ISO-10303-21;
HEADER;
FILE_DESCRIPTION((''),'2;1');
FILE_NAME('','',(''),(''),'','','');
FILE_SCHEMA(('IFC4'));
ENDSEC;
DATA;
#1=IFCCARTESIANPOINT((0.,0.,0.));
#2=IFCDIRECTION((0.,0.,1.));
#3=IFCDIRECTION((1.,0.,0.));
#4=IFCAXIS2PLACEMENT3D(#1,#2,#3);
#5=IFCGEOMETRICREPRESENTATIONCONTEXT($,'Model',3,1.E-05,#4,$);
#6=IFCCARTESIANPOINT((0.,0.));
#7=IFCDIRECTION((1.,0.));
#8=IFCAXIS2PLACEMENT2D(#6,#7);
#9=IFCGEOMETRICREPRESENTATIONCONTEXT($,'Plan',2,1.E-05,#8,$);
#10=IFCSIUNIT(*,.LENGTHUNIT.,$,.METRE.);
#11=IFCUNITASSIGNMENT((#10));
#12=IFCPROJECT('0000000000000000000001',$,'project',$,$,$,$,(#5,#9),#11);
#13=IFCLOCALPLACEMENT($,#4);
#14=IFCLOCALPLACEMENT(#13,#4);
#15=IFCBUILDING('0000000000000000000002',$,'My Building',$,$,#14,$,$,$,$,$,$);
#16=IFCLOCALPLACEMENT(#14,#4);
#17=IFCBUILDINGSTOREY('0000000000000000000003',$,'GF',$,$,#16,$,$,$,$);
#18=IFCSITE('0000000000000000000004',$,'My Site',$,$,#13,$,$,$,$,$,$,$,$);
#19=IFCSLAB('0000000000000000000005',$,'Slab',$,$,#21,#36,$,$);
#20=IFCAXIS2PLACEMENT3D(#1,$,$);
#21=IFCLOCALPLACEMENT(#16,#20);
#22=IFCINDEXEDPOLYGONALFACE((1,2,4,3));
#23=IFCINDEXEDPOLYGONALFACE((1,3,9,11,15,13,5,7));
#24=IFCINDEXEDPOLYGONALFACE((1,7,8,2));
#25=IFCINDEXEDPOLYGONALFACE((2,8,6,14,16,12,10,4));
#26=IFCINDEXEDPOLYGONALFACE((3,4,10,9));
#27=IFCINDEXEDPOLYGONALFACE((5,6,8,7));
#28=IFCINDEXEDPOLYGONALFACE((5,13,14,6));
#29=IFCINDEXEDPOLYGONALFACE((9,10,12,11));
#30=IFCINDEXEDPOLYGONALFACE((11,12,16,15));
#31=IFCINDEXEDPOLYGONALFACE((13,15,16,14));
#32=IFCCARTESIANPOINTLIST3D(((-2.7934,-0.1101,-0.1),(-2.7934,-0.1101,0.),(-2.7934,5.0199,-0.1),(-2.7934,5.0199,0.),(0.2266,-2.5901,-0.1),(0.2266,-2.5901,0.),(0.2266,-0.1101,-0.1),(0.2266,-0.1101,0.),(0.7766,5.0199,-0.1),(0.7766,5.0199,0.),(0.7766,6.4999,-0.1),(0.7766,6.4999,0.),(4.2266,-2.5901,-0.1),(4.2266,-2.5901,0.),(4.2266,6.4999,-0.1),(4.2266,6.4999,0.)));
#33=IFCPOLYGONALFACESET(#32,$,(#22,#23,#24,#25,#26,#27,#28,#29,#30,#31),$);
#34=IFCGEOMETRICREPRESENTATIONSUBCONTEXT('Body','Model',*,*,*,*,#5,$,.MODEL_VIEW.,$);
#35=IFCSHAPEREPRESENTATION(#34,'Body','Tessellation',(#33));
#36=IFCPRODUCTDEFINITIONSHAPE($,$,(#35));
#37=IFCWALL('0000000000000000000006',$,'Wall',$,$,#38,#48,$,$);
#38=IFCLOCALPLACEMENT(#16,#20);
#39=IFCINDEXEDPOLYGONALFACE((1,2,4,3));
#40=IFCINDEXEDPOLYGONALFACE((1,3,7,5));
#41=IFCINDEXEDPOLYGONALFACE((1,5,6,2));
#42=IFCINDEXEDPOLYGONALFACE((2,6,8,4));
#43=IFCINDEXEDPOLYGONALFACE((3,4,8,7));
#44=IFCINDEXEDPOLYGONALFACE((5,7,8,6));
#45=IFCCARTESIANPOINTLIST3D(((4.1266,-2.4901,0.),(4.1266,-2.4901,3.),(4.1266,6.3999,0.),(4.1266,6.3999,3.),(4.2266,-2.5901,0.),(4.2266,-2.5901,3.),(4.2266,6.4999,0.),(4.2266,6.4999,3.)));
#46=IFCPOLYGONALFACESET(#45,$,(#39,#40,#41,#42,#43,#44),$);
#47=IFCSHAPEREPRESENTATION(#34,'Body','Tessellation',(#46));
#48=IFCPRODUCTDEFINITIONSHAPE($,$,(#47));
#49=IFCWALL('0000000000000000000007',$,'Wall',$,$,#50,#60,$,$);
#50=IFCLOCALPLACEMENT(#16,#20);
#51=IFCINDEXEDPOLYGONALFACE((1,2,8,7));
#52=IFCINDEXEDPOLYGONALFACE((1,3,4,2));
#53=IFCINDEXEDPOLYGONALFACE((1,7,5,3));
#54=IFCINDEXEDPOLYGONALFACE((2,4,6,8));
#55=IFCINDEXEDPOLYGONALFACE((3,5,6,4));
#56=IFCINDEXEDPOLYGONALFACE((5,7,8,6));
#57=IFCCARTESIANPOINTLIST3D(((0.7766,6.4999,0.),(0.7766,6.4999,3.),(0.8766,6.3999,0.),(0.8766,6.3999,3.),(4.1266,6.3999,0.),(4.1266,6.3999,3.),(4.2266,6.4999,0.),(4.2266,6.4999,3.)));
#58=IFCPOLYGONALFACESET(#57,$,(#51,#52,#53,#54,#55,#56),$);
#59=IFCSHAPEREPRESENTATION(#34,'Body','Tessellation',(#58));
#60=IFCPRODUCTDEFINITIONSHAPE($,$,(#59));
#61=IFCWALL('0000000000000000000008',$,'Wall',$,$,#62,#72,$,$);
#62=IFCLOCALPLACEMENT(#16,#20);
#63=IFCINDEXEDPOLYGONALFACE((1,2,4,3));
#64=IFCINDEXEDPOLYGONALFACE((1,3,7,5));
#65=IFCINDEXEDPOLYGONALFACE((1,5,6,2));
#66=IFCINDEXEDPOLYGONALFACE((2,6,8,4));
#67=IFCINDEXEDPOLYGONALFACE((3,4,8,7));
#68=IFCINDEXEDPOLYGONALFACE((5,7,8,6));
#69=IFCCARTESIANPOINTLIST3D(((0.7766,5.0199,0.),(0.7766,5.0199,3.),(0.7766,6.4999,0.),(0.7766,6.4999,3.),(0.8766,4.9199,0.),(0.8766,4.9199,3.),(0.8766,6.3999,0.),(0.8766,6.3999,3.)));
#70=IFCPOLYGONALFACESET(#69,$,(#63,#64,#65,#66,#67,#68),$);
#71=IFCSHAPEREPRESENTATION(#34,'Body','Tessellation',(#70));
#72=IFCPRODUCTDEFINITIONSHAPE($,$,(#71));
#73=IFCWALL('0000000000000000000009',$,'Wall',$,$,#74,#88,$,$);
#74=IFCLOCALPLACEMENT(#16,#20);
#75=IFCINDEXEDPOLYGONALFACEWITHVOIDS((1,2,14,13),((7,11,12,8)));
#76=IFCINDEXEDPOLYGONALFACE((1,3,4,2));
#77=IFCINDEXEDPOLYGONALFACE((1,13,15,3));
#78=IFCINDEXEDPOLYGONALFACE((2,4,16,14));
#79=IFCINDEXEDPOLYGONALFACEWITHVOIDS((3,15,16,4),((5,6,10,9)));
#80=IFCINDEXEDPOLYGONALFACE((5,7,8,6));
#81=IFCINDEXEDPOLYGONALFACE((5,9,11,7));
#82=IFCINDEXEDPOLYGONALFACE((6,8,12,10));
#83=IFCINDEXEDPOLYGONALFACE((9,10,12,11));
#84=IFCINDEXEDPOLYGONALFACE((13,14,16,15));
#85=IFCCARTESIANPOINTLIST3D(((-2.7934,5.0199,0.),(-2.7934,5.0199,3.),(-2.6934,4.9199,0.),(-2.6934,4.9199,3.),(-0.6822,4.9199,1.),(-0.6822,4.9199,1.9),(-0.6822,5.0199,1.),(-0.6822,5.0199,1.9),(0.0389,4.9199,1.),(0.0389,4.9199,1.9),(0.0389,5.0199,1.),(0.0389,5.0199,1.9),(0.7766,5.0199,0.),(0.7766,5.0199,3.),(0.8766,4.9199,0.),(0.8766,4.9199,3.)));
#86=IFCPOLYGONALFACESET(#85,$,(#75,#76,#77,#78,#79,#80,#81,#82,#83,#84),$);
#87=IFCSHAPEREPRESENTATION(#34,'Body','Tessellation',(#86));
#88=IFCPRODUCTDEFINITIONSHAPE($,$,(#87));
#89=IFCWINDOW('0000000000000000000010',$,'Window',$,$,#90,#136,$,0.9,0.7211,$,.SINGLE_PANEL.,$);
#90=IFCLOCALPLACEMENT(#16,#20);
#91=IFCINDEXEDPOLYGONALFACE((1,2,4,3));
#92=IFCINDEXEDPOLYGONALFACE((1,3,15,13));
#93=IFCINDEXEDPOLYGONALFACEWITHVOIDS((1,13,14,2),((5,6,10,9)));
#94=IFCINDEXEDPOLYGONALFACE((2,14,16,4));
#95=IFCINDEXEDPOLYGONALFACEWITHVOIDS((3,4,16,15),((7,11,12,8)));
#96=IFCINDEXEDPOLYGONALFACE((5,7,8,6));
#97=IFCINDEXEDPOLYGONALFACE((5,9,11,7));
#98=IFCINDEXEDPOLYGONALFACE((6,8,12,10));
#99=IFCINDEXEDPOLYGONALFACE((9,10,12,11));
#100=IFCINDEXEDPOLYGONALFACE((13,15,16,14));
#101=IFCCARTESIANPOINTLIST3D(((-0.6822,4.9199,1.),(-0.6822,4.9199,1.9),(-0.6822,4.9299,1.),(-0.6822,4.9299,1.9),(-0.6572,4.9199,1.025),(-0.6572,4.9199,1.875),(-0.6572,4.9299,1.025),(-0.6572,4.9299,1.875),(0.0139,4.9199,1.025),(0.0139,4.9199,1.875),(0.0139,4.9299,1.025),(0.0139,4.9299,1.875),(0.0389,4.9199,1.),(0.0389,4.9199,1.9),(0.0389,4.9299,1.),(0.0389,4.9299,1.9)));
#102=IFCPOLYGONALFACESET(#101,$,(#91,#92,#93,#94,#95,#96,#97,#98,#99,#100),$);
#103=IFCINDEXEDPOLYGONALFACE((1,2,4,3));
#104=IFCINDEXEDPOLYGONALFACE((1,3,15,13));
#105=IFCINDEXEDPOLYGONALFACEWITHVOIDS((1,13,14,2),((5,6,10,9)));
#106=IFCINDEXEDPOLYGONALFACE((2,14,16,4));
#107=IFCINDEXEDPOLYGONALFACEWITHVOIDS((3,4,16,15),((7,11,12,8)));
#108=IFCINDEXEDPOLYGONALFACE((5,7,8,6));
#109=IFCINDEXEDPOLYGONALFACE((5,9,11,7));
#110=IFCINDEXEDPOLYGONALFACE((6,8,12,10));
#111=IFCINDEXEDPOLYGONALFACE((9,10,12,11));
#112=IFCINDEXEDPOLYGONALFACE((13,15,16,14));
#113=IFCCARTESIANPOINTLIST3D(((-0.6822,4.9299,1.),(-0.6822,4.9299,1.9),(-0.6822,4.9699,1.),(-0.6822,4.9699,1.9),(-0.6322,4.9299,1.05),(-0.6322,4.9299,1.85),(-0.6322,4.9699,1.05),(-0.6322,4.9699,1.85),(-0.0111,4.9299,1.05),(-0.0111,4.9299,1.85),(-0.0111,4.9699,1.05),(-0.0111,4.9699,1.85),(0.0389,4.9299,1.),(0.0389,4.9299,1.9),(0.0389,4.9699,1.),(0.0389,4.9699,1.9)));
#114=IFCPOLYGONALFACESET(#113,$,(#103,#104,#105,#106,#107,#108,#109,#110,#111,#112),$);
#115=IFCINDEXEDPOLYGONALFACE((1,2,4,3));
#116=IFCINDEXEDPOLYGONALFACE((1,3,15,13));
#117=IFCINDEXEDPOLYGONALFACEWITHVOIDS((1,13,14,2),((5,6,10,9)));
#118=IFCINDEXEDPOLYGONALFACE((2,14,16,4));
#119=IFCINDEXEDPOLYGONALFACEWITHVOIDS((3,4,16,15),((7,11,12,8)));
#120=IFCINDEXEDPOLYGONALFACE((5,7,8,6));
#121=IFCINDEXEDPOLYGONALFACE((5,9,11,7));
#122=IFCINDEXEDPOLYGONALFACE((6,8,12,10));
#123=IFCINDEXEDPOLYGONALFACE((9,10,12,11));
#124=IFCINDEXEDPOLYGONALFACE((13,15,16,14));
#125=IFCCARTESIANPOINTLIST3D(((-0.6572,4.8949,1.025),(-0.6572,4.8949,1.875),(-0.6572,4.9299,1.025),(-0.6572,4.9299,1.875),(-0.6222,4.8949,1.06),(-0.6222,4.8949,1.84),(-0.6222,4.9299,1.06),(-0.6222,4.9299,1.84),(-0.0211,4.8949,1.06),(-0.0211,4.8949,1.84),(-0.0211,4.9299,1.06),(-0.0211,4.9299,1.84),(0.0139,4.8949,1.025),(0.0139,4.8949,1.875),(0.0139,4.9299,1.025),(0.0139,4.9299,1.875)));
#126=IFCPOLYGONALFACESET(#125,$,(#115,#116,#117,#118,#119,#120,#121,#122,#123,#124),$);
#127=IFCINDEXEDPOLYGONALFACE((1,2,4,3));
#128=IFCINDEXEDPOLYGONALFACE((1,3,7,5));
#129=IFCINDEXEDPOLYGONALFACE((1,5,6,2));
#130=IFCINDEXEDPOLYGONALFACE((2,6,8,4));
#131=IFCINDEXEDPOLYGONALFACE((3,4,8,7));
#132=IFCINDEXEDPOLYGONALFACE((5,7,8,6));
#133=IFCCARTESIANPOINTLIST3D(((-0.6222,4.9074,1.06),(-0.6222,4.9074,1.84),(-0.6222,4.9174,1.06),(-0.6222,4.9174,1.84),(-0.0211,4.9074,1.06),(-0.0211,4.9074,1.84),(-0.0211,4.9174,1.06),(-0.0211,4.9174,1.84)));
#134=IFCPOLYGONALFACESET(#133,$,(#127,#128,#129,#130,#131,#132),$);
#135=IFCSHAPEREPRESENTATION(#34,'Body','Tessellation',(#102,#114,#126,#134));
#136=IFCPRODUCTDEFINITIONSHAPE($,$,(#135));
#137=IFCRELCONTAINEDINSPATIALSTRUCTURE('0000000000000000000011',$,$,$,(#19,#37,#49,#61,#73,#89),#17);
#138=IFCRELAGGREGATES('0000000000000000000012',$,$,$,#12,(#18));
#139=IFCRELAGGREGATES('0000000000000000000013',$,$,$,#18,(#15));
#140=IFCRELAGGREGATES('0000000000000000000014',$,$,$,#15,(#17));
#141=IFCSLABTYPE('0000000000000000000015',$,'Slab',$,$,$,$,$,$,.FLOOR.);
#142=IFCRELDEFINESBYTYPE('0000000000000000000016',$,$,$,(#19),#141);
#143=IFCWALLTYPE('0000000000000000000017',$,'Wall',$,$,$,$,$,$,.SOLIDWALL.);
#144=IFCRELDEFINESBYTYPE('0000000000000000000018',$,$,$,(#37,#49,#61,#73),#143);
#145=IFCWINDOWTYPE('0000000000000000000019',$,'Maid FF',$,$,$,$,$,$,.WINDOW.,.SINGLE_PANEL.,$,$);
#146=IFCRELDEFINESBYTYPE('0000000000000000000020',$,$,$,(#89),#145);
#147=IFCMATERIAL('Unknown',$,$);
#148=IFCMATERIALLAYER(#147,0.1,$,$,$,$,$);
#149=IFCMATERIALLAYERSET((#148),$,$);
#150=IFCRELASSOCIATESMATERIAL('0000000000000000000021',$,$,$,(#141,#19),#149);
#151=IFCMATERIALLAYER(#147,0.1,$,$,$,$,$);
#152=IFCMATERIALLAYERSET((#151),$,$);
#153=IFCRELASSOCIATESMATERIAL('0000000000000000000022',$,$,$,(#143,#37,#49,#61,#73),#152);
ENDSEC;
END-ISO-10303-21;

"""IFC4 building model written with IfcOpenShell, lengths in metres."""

from ifc_helpers import new_model, entity, si_unit, frame, origin_with_axes, origin_2d_with_axis, place, context, subcontext, project, spatial, line, indexed_curve, outline, extrude, shape, source, transform, mapped, material, layer, layer_set, layer_usage, type_object, type_shapes, element, fill, save


model = new_model("IFC4")

# Units and contexts
model_context = context("Model", 3, precision=1e-05, world=origin_with_axes())
plan_context = context("Plan", 2, precision=1e-05, world=origin_2d_with_axis())
body_context_1 = subcontext(model_context, "Body", "Model", "MODEL_VIEW")
body_context_2 = subcontext(plan_context, "Body", "Plan", "PLAN_VIEW")
ifc_project = project(units=[si_unit("LENGTHUNIT", "METRE")], contexts=[model_context, plan_context])

# Site, building, storey
site_placement = place(None, origin_with_axes())
site = spatial("IfcSite", under=ifc_project, at=site_placement, Name="My Site")
building_placement = place(site_placement, origin_with_axes())
building = spatial("IfcBuilding", under=site, at=building_placement, Name="My Building")
storey_placement = place(building_placement, origin_with_axes())
storey = spatial("IfcBuildingStorey", under=building, at=storey_placement, Name="GF")

# Slab
ifc_material_1 = material(Name="Unknown")
ifc_layer_1 = layer(ifc_material_1, 0.1)
ifc_layer_set_1 = layer_set([ifc_layer_1])
ifc_layer_usage_1 = layer_usage(ifc_layer_set_1, "AXIS3", "POSITIVE", -0.1)
slab_type_1 = type_object("IfcSlabType", Name="Slab", PredefinedType="FLOOR", material=ifc_layer_set_1)
slab_1_placement = place(storey_placement, frame((4.2266, -2.5901, 0.0), z_axis=(0.0, 0.0, 1.0), x_axis=(1.0, 0.0, 0.0)))
element("IfcSlab", 1, at=slab_1_placement, inside=storey, type_object=slab_type_1, material=ifc_layer_usage_1, Name="Slab", context=body_context_1, shape_type="SweptSolid", body=[
    extrude(outline(indexed_curve([(0.0, 0.0), (0.0, 9.09), (-3.45, 9.09), (-3.45, 7.61), (-7.02, 7.61), (-7.02, 2.48), (-4.0, 2.48), (-4.0, 0.0), (0.0, 0.0)])), frame((0.0, 0.0, -0.1), z_axis=(0.0, 0.0, 1.0), x_axis=(1.0, 0.0, 0.0)), (0.0, 0.0, 1.0), 0.1),
])

# Shared definitions
ifc_layer_2 = layer(ifc_material_1, 0.1)
ifc_layer_set_2 = layer_set([ifc_layer_2])
wall_type = type_object("IfcWallType", Name="Wall", PredefinedType="SOLIDWALL", material=ifc_layer_set_2)

# Walls
ifc_layer_usage_2 = layer_usage(ifc_layer_set_2, "AXIS2", "POSITIVE", 0.0)
wall_1_placement = place(storey_placement, frame((4.2266, -2.5901, 0.0), z_axis=(0.0, 0.0, 1.0), x_axis=(0.0, 1.0, 0.0)))
element("IfcWall", 2, at=wall_1_placement, inside=storey, type_object=wall_type, material=ifc_layer_usage_2, Name="Wall", context=body_context_1, shape_type="SweptSolid", body=[
    extrude(outline(indexed_curve([(0.0, 0.0), (0.1, 0.1), (8.99, 0.1), (9.09, 0.0)], segments=[line(1, 2, 3, 4, 1)])), origin_with_axes(), (0.0, 0.0, 1.0), 3.0),
])
ifc_layer_usage_3 = layer_usage(ifc_layer_set_2, "AXIS2", "POSITIVE", 0.0)
wall_2_placement = place(storey_placement, frame((4.2266, 6.4999, 0.0), z_axis=(0.0, 0.0, 1.0), x_axis=(-1.0, 0.0, 0.0)))
element("IfcWall", 3, at=wall_2_placement, inside=storey, type_object=wall_type, material=ifc_layer_usage_3, Name="Wall", context=body_context_1, shape_type="SweptSolid", body=[
    extrude(outline(indexed_curve([(0.0, 0.0), (0.1, 0.1), (3.35, 0.1), (3.45, 0.0)], segments=[line(1, 2, 3, 4, 1)])), origin_with_axes(), (0.0, 0.0, 1.0), 3.0),
])
ifc_layer_usage_4 = layer_usage(ifc_layer_set_2, "AXIS2", "POSITIVE", 0.0)
wall_3_placement = place(storey_placement, frame((0.7766, 6.4999, 0.0), z_axis=(0.0, 0.0, 1.0), x_axis=(0.0, -1.0, 0.0)))
element("IfcWall", 4, at=wall_3_placement, inside=storey, type_object=wall_type, material=ifc_layer_usage_4, Name="Wall", context=body_context_1, shape_type="SweptSolid", body=[
    extrude(outline(indexed_curve([(0.0, 0.0), (0.1, 0.1), (1.58, 0.1), (1.48, 0.0)], segments=[line(1, 2, 3, 4, 1)])), origin_with_axes(), (0.0, 0.0, 1.0), 3.0),
])

# Wall, opening, window
ifc_layer_usage_5 = layer_usage(ifc_layer_set_2, "AXIS2", "POSITIVE", 0.0)
wall_4_placement = place(storey_placement, frame((0.7766, 5.0199, 0.0), z_axis=(0.0, 0.0, 1.0), x_axis=(-1.0, 0.0, 0.0)))
wall_4 = element("IfcWall", 5, at=wall_4_placement, inside=storey, type_object=wall_type, material=ifc_layer_usage_5, Name="Wall", context=body_context_1, shape_type="SweptSolid", body=[
    extrude(outline(indexed_curve([(0.0, 0.0), (-0.1, 0.1), (3.47, 0.1), (3.57, 0.0)], segments=[line(1, 2, 3, 4, 1)])), origin_with_axes(), (0.0, 0.0, 1.0), 3.0),
])
shared_shape_1 = source(origin_with_axes(), body_context_1, "Body", "SweptSolid", [
    extrude(outline(indexed_curve([(0.0, 0.0), (0.7211, 0.0), (0.7211, 0.9), (0.0, 0.9)], segments=[line(1, 2, 3, 4, 1)])), frame((0.0, -0.6, 0.0), z_axis=(0.0, -1.0, 0.0), x_axis=(1.0, 0.0, 0.0)), (0.0, 0.0, -1.0), 1.2),
])
opening_1_placement = place(wall_4_placement, frame((0.7377, 0.0, 1.0), z_axis=(0.0, 0.0, 1.0), x_axis=(1.0, 0.0, 0.0)))
opening_1 = element("IfcOpeningElement", 6, at=opening_1_placement, cuts=wall_4, PredefinedType="OPENING", context=body_context_1, shape_type="MappedRepresentation", body=[
    mapped(shared_shape_1, transform((0.0, 0.0, 0.0), x_axis=(1.0, 0.0, 0.0), y_axis=(0.0, 1.0, 0.0), z_axis=(0.0, 0.0, 1.0), scale=1.0)),
])
window_type_1 = type_object("IfcWindowType", Name="Maid FF", PartitioningType="SINGLE_PANEL", PredefinedType="WINDOW")
shared_shape_2 = source(origin_with_axes(), body_context_1, "Body", "SweptSolid", [
    extrude(outline(indexed_curve([(0.0, 0.0), (0.7211, 0.0), (0.7211, 0.9), (0.0, 0.9)], segments=[line(1, 2, 3, 4, 1)]), holes=[indexed_curve([(0.025, 0.025), (0.6961, 0.025), (0.6961, 0.875), (0.025, 0.875)], segments=[line(1, 2, 3, 4, 1)])]), frame((0.0, 0.09, 0.0), z_axis=(0.0, -1.0, 0.0), x_axis=(1.0, 0.0, 0.0)), (0.0, 0.0, -1.0), 0.01),
    extrude(outline(indexed_curve([(0.0, 0.0), (0.7211, 0.0), (0.7211, 0.9), (0.0, 0.9)], segments=[line(1, 2, 3, 4, 1)]), holes=[indexed_curve([(0.05, 0.05), (0.6711, 0.05), (0.6711, 0.85), (0.05, 0.85)], segments=[line(1, 2, 3, 4, 1)])]), frame((0.0, 0.05, 0.0), z_axis=(0.0, -1.0, 0.0), x_axis=(1.0, 0.0, 0.0)), (0.0, 0.0, -1.0), 0.04),
    extrude(outline(indexed_curve([(0.0, 0.0), (0.6711, 0.0), (0.6711, 0.85), (0.0, 0.85)], segments=[line(1, 2, 3, 4, 1)]), holes=[indexed_curve([(0.035, 0.035), (0.6361, 0.035), (0.6361, 0.815), (0.035, 0.815)], segments=[line(1, 2, 3, 4, 1)])]), frame((0.025, 0.09, 0.025), z_axis=(0.0, -1.0, 0.0), x_axis=(1.0, 0.0, 0.0)), (0.0, 0.0, -1.0), 0.035),
    extrude(outline(indexed_curve([(0.035, 0.035), (0.6361, 0.035), (0.6361, 0.815), (0.035, 0.815)], segments=[line(1, 2, 3, 4, 1)])), frame((0.025, 0.1025, 0.025), z_axis=(0.0, -1.0, 0.0), x_axis=(1.0, 0.0, 0.0)), (0.0, 0.0, -1.0), 0.01),
])
shared_shape_3 = source(origin_with_axes(), body_context_2, "Body", "Curve2D", [
    entity("IfcIndexedPolyCurve", entity("IfcCartesianPointList2D", [[0.05, 0.05], [0.6711, 0.05]])),
    entity("IfcIndexedPolyCurve", entity("IfcCartesianPointList2D", [[0.0, 0.1], [0.025, 0.1], [0.025, 0.09], [0.05, 0.09], [0.05, 0.05], [0.0, 0.05]]), [entity("IfcLineIndex", [1, 2, 3, 4, 5, 6, 1])]),
    entity("IfcIndexedPolyCurve", entity("IfcCartesianPointList2D", [[0.7211, 0.1], [0.6961, 0.1], [0.6961, 0.09], [0.6711, 0.09], [0.6711, 0.05], [0.7211, 0.05]]), [entity("IfcLineIndex", [1, 2, 3, 4, 5, 6, 1])]),
    entity("IfcIndexedPolyCurve", entity("IfcCartesianPointList2D", [[0.025, 0.09], [0.06, 0.09], [0.06, 0.125], [0.025, 0.125]]), [entity("IfcLineIndex", [1, 2, 3, 4, 1])]),
    entity("IfcIndexedPolyCurve", entity("IfcCartesianPointList2D", [[0.6961, 0.09], [0.6611, 0.09], [0.6611, 0.125], [0.6961, 0.125]]), [entity("IfcLineIndex", [1, 2, 3, 4, 1])]),
    entity("IfcIndexedPolyCurve", entity("IfcCartesianPointList2D", [[0.06, 0.09], [0.6611, 0.09]])),
    entity("IfcIndexedPolyCurve", entity("IfcCartesianPointList2D", [[0.06, 0.125], [0.6611, 0.125]])),
    entity("IfcIndexedPolyCurve", entity("IfcCartesianPointList2D", [[0.06, 0.1075], [0.6611, 0.1075]])),
])
type_shapes(window_type_1, [shared_shape_2, shared_shape_3])
window_1_placement = place(opening_1_placement, frame((0.0, 0.0, 0.0), z_axis=(0.0, 0.0, 1.0), x_axis=(1.0, 0.0, 0.0)))
window_1 = element("IfcWindow", 7, at=window_1_placement, inside=storey, type_object=window_type_1, Name="Window", OverallHeight=0.9, OverallWidth=0.7211, PartitioningType="SINGLE_PANEL", shapes=[
    shape(body_context_1, "Body", "MappedRepresentation", [mapped(shared_shape_2, transform((0.0, 0.0, 0.0), x_axis=(1.0, 0.0, 0.0), y_axis=(0.0, 1.0, 0.0), z_axis=(0.0, 0.0, 1.0), scale=1.0))]),
    shape(body_context_2, "Body", "MappedRepresentation", [mapped(shared_shape_3, transform((0.0, 0.0, 0.0), x_axis=(1.0, 0.0, 0.0), y_axis=(0.0, 1.0, 0.0), z_axis=(0.0, 0.0, 1.0), scale=1.0))]),
])
fill(opening_1, window_1)

save(model, "model.ifc")
